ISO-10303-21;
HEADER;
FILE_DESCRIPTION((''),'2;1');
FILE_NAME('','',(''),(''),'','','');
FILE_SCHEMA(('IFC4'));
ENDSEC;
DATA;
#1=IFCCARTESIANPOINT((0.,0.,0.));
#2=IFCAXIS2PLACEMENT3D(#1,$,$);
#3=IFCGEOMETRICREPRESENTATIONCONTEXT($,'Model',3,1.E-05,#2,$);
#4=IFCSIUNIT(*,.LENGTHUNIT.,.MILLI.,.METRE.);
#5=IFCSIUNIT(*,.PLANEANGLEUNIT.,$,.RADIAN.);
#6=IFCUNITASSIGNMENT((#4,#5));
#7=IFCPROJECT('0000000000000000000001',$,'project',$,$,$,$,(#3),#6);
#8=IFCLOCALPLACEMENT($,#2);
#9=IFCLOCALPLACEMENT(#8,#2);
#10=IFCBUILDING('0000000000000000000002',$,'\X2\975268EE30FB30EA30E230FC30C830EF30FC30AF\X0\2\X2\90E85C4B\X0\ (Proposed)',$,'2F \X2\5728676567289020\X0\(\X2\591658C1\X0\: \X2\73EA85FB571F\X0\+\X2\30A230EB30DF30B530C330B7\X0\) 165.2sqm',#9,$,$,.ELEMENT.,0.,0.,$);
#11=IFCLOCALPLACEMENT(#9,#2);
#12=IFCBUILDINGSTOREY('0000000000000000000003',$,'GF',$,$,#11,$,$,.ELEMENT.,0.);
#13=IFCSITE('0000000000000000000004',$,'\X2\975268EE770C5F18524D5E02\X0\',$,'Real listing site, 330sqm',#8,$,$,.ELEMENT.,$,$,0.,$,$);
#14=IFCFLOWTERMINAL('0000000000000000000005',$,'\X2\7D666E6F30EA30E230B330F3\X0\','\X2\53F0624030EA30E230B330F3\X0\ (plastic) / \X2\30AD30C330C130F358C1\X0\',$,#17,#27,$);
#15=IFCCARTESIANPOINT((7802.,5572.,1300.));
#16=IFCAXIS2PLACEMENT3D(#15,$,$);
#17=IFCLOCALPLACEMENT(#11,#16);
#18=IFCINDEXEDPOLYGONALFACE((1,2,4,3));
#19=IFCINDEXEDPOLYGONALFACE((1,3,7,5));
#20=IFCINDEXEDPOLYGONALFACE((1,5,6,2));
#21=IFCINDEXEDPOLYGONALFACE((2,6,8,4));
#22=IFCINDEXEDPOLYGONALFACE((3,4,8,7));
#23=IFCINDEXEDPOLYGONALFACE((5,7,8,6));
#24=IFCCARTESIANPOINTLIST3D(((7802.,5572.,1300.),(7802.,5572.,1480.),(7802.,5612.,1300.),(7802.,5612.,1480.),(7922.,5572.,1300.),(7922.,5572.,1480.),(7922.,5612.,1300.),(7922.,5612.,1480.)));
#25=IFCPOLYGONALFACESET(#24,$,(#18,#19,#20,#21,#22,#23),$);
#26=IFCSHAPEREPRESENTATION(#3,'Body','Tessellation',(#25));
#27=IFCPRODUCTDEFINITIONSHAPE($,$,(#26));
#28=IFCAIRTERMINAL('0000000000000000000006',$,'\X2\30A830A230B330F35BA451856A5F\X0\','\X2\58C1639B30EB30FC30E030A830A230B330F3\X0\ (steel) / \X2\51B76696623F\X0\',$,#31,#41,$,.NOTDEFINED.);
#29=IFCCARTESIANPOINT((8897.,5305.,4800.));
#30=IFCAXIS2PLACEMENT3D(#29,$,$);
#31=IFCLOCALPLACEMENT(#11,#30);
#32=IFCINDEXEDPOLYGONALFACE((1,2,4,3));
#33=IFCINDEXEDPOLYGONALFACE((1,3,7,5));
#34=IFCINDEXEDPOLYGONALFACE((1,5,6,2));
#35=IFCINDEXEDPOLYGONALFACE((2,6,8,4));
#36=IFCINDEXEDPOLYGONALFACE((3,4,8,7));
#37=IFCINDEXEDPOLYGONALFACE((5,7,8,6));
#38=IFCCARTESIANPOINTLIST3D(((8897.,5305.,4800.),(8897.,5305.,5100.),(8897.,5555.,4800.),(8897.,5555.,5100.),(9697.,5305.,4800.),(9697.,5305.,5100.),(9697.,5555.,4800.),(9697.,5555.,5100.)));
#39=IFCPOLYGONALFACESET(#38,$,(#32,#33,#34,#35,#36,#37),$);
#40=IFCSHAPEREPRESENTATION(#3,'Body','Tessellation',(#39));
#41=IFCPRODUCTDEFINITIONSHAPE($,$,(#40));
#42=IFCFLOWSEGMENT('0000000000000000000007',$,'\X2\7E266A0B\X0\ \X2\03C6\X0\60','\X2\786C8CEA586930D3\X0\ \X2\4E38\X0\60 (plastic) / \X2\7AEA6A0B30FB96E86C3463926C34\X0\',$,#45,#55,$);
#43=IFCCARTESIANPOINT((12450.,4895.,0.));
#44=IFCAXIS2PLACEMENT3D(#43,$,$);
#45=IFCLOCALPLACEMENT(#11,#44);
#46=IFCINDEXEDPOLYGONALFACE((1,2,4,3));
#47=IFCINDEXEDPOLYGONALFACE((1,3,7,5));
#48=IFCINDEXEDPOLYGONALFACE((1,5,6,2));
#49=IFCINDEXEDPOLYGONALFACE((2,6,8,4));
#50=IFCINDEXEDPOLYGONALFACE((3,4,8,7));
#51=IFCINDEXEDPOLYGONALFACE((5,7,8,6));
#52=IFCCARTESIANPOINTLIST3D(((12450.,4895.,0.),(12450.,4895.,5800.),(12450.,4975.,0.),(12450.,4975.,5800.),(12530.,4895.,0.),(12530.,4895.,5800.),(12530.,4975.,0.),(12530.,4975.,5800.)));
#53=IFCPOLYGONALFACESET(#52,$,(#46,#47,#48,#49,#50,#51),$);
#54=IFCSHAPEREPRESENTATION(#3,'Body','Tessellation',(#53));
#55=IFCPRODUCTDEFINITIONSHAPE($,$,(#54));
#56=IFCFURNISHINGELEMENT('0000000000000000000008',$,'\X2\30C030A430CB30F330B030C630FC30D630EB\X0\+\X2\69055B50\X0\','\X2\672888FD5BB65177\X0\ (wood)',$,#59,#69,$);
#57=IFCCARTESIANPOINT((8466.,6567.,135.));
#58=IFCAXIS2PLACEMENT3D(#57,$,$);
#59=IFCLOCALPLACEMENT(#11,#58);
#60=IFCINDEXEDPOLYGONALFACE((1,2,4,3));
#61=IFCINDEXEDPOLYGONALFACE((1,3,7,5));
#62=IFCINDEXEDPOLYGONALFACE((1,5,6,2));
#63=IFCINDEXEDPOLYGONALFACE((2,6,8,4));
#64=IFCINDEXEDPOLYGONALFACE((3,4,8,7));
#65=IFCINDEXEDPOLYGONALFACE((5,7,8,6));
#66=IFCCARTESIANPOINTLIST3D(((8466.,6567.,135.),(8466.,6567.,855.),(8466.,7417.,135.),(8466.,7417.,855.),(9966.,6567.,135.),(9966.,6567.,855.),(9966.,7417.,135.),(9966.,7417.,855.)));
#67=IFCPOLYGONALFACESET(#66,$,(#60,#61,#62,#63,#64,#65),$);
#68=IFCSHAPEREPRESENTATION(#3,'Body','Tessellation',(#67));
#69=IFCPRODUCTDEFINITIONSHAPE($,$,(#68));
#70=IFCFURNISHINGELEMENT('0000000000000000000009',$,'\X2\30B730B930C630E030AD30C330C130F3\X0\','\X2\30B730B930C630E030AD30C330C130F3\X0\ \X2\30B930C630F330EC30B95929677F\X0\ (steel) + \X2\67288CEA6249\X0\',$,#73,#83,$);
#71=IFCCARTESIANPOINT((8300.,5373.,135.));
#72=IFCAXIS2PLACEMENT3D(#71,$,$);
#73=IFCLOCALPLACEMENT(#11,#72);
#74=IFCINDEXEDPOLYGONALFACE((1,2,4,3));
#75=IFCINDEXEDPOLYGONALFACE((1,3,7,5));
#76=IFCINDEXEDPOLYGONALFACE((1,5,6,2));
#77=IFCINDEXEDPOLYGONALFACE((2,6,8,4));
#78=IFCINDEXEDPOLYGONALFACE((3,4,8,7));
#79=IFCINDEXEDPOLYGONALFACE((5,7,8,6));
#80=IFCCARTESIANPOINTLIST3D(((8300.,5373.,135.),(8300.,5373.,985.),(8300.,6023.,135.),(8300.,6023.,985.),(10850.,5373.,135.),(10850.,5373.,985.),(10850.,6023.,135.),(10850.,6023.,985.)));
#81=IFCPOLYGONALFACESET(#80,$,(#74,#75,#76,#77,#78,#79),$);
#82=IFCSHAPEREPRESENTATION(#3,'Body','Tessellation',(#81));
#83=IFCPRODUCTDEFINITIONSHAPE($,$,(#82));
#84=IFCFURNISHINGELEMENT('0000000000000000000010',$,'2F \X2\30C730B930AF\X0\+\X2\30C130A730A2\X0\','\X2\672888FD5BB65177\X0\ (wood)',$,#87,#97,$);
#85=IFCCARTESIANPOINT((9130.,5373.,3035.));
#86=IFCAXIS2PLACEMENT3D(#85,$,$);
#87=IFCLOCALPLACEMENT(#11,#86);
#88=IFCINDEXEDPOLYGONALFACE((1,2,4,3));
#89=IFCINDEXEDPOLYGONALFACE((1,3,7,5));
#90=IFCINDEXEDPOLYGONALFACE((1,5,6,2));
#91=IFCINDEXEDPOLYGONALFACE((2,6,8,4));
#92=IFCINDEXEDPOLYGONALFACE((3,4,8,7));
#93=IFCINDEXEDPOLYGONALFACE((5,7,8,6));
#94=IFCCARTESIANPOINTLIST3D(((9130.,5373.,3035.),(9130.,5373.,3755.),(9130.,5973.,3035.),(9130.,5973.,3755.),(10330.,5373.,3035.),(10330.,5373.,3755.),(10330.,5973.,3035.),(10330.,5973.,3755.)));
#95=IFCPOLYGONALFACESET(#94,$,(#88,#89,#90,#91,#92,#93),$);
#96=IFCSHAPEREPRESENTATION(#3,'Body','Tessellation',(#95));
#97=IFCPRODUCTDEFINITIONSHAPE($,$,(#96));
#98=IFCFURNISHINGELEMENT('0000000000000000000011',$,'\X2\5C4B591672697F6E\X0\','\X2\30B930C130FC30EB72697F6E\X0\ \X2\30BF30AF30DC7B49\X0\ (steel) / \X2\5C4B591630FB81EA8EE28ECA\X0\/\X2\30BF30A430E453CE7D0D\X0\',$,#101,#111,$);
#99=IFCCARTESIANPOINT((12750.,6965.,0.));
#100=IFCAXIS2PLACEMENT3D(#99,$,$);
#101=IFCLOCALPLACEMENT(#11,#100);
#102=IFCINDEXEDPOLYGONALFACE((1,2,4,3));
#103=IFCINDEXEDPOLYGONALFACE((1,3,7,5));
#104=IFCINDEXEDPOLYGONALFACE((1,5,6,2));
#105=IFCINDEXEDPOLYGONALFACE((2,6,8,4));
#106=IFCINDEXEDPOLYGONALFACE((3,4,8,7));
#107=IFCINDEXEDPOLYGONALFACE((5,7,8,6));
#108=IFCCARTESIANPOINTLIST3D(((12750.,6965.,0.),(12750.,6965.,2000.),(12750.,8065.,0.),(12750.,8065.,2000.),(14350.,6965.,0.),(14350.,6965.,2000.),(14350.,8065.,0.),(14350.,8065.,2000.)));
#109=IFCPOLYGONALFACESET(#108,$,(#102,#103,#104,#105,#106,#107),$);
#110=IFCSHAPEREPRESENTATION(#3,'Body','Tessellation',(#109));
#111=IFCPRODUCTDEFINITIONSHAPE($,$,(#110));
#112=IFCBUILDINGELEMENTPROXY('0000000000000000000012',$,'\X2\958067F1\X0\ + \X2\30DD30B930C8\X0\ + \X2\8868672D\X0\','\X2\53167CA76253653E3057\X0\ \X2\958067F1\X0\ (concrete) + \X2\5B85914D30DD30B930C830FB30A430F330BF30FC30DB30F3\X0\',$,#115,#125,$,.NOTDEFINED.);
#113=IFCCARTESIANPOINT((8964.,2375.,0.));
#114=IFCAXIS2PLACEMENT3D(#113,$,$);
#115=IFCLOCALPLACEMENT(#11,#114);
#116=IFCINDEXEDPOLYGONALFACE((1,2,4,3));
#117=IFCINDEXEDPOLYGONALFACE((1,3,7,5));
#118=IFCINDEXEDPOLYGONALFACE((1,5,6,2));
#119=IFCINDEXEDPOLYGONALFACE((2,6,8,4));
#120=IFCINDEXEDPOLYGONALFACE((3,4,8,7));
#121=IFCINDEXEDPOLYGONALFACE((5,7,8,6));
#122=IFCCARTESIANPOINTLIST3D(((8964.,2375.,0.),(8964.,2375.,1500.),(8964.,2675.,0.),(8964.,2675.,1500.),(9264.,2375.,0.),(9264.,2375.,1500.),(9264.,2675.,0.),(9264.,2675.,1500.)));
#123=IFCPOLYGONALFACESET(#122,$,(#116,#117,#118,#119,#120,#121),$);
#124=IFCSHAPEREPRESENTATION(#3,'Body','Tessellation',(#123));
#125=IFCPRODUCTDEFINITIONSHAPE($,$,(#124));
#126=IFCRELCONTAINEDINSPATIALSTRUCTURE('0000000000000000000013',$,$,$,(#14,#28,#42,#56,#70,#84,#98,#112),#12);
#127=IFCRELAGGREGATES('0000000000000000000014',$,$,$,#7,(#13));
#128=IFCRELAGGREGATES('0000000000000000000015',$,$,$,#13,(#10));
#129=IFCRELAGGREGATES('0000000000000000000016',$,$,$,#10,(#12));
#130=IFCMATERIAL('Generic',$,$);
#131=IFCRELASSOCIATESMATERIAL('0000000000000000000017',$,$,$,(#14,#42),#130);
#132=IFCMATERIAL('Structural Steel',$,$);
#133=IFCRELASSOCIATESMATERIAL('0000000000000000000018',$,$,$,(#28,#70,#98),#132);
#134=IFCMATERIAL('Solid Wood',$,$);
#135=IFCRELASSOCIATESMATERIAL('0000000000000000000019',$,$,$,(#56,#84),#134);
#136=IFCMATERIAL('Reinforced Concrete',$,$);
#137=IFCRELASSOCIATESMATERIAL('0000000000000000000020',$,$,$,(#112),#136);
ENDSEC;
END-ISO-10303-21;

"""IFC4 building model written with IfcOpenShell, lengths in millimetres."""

from ifc_helpers import new_model, si_unit, frame, frame_2d, origin, place, context, project, spatial, rectangle, extrude, material, element, save


model = new_model("IFC4")

# Units and contexts
model_context = context("Model", 3, precision=1e-05, world=origin())
ifc_project = project(units=[si_unit("LENGTHUNIT", "METRE", prefix="MILLI"), si_unit("PLANEANGLEUNIT", "RADIAN")], contexts=[model_context])

# Site, building, storey
site_placement = place(None, origin())
site = spatial("IfcSite", under=ifc_project, at=site_placement, Name="青森県弘前市", ObjectType="Real listing site, 330sqm", CompositionType="ELEMENT", RefElevation=0.0)
building_placement = place(site_placement, origin())
building = spatial("IfcBuilding", under=site, at=building_placement, Name="青森・リモートワーク2部屋 (Proposed)", ObjectType="2F 在来木造(外壁: 珪藻土+アルミサッシ) 165.2sqm", CompositionType="ELEMENT", ElevationOfRefHeight=0.0, ElevationOfTerrain=0.0)
storey_placement = place(building_placement, origin())
storey = spatial("IfcBuildingStorey", under=building, at=storey_placement, Name="GF", CompositionType="ELEMENT", Elevation=0.0)

# Shared definitions
ifc_material_1 = material(Name="Solid Wood")
ifc_material_2 = material(Name="Structural Steel")

# Shared definitions
ifc_material_3 = material(Name="Reinforced Concrete")

# Flow terminal
ifc_material_4 = material(Name="Generic")
flow_terminal_1_placement = place(storey_placement, frame((7802.0, 5572.0, 1300.0)))
element("IfcFlowTerminal", 1, at=flow_terminal_1_placement, inside=storey, material=ifc_material_4, Name="給湯リモコン", Description="台所リモコン (plastic) / キッチン壁", context=model_context, shape_type="SweptSolid", body=[
    extrude(rectangle(XDim=120.0, YDim=40.0, at=frame_2d((60.0, 20.0))), frame((7802.0, 5572.0, 1300.0)), (0.0, 0.0, 1.0), 180.0),
])

# Air terminal
air_terminal_placement = place(storey_placement, frame((8897.0, 5305.0, 4800.0)))
element("IfcAirTerminal", 2, at=air_terminal_placement, inside=storey, material=ifc_material_2, Name="エアコン室内機", Description="壁掛ルームエアコン (steel) / 冷暖房", PredefinedType="NOTDEFINED", context=model_context, shape_type="SweptSolid", body=[
    extrude(rectangle(XDim=800.0, YDim=250.0, at=frame_2d((400.0, 125.0))), frame((8897.0, 5305.0, 4800.0)), (0.0, 0.0, 1.0), 300.0),
])

# Flow segment
flow_segment_placement = place(storey_placement, frame((12450.0, 4895.0, 0.0)))
element("IfcFlowSegment", 3, at=flow_segment_placement, inside=storey, material=ifc_material_4, Name="縦樋 φ60", Description="硬質塩ビ 丸60 (plastic) / 竪樋・雨水排水", context=model_context, shape_type="SweptSolid", body=[
    extrude(rectangle(XDim=80.0, YDim=80.0, at=frame_2d((40.0, 40.0))), frame((12450.0, 4895.0, 0.0)), (0.0, 0.0, 1.0), 5800.0),
])

# Furnishing elements
furnishing_1_placement = place(storey_placement, frame((8466.0, 6567.0, 135.0)))
element("IfcFurnishingElement", 4, at=furnishing_1_placement, inside=storey, material=ifc_material_1, Name="ダイニングテーブル+椅子", Description="木製家具 (wood)", context=model_context, shape_type="SweptSolid", body=[
    extrude(rectangle(XDim=1500.0, YDim=850.0, at=frame_2d((750.0, 425.0))), frame((8466.0, 6567.0, 135.0)), (0.0, 0.0, 1.0), 720.0),
])
furnishing_2_placement = place(storey_placement, frame((8300.0, 5373.0, 135.0)))
element("IfcFurnishingElement", 5, at=furnishing_2_placement, inside=storey, material=ifc_material_2, Name="システムキッチン", Description="システムキッチン ステンレス天板 (steel) + 木質扉", context=model_context, shape_type="SweptSolid", body=[
    extrude(rectangle(XDim=2550.0, YDim=650.0, at=frame_2d((1275.0, 325.0))), frame((8300.0, 5373.0, 135.0)), (0.0, 0.0, 1.0), 850.0),
])
furnishing_3_placement = place(storey_placement, frame((9130.0, 5373.0, 3035.0)))
element("IfcFurnishingElement", 6, at=furnishing_3_placement, inside=storey, material=ifc_material_1, Name="2F デスク+チェア", Description="木製家具 (wood)", context=model_context, shape_type="SweptSolid", body=[
    extrude(rectangle(XDim=1200.0, YDim=600.0, at=frame_2d((600.0, 300.0))), frame((9130.0, 5373.0, 3035.0)), (0.0, 0.0, 1.0), 720.0),
])
furnishing_4_placement = place(storey_placement, frame((12750.0, 6965.0, 0.0)))
element("IfcFurnishingElement", 7, at=furnishing_4_placement, inside=storey, material=ifc_material_2, Name="屋外物置", Description="スチール物置 タクボ等 (steel) / 屋外・自転車/タイヤ収納", context=model_context, shape_type="SweptSolid", body=[
    extrude(rectangle(XDim=1600.0, YDim=1100.0, at=frame_2d((800.0, 550.0))), frame((12750.0, 6965.0, 0.0)), (0.0, 0.0, 1.0), 2000.0),
])

# Building element proxy
proxy_placement = place(storey_placement, frame((8964.0, 2375.0, 0.0)))
element("IfcBuildingElementProxy", 8, at=proxy_placement, inside=storey, material=ifc_material_3, Name="門柱 + ポスト + 表札", Description="化粧打放し 門柱 (concrete) + 宅配ポスト・インターホン", PredefinedType="NOTDEFINED", context=model_context, shape_type="SweptSolid", body=[
    extrude(rectangle(XDim=300.0, YDim=300.0, at=frame_2d((150.0, 150.0))), frame((8964.0, 2375.0, 0.0)), (0.0, 0.0, 1.0), 1500.0),
])

save(model, "model.ifc")
